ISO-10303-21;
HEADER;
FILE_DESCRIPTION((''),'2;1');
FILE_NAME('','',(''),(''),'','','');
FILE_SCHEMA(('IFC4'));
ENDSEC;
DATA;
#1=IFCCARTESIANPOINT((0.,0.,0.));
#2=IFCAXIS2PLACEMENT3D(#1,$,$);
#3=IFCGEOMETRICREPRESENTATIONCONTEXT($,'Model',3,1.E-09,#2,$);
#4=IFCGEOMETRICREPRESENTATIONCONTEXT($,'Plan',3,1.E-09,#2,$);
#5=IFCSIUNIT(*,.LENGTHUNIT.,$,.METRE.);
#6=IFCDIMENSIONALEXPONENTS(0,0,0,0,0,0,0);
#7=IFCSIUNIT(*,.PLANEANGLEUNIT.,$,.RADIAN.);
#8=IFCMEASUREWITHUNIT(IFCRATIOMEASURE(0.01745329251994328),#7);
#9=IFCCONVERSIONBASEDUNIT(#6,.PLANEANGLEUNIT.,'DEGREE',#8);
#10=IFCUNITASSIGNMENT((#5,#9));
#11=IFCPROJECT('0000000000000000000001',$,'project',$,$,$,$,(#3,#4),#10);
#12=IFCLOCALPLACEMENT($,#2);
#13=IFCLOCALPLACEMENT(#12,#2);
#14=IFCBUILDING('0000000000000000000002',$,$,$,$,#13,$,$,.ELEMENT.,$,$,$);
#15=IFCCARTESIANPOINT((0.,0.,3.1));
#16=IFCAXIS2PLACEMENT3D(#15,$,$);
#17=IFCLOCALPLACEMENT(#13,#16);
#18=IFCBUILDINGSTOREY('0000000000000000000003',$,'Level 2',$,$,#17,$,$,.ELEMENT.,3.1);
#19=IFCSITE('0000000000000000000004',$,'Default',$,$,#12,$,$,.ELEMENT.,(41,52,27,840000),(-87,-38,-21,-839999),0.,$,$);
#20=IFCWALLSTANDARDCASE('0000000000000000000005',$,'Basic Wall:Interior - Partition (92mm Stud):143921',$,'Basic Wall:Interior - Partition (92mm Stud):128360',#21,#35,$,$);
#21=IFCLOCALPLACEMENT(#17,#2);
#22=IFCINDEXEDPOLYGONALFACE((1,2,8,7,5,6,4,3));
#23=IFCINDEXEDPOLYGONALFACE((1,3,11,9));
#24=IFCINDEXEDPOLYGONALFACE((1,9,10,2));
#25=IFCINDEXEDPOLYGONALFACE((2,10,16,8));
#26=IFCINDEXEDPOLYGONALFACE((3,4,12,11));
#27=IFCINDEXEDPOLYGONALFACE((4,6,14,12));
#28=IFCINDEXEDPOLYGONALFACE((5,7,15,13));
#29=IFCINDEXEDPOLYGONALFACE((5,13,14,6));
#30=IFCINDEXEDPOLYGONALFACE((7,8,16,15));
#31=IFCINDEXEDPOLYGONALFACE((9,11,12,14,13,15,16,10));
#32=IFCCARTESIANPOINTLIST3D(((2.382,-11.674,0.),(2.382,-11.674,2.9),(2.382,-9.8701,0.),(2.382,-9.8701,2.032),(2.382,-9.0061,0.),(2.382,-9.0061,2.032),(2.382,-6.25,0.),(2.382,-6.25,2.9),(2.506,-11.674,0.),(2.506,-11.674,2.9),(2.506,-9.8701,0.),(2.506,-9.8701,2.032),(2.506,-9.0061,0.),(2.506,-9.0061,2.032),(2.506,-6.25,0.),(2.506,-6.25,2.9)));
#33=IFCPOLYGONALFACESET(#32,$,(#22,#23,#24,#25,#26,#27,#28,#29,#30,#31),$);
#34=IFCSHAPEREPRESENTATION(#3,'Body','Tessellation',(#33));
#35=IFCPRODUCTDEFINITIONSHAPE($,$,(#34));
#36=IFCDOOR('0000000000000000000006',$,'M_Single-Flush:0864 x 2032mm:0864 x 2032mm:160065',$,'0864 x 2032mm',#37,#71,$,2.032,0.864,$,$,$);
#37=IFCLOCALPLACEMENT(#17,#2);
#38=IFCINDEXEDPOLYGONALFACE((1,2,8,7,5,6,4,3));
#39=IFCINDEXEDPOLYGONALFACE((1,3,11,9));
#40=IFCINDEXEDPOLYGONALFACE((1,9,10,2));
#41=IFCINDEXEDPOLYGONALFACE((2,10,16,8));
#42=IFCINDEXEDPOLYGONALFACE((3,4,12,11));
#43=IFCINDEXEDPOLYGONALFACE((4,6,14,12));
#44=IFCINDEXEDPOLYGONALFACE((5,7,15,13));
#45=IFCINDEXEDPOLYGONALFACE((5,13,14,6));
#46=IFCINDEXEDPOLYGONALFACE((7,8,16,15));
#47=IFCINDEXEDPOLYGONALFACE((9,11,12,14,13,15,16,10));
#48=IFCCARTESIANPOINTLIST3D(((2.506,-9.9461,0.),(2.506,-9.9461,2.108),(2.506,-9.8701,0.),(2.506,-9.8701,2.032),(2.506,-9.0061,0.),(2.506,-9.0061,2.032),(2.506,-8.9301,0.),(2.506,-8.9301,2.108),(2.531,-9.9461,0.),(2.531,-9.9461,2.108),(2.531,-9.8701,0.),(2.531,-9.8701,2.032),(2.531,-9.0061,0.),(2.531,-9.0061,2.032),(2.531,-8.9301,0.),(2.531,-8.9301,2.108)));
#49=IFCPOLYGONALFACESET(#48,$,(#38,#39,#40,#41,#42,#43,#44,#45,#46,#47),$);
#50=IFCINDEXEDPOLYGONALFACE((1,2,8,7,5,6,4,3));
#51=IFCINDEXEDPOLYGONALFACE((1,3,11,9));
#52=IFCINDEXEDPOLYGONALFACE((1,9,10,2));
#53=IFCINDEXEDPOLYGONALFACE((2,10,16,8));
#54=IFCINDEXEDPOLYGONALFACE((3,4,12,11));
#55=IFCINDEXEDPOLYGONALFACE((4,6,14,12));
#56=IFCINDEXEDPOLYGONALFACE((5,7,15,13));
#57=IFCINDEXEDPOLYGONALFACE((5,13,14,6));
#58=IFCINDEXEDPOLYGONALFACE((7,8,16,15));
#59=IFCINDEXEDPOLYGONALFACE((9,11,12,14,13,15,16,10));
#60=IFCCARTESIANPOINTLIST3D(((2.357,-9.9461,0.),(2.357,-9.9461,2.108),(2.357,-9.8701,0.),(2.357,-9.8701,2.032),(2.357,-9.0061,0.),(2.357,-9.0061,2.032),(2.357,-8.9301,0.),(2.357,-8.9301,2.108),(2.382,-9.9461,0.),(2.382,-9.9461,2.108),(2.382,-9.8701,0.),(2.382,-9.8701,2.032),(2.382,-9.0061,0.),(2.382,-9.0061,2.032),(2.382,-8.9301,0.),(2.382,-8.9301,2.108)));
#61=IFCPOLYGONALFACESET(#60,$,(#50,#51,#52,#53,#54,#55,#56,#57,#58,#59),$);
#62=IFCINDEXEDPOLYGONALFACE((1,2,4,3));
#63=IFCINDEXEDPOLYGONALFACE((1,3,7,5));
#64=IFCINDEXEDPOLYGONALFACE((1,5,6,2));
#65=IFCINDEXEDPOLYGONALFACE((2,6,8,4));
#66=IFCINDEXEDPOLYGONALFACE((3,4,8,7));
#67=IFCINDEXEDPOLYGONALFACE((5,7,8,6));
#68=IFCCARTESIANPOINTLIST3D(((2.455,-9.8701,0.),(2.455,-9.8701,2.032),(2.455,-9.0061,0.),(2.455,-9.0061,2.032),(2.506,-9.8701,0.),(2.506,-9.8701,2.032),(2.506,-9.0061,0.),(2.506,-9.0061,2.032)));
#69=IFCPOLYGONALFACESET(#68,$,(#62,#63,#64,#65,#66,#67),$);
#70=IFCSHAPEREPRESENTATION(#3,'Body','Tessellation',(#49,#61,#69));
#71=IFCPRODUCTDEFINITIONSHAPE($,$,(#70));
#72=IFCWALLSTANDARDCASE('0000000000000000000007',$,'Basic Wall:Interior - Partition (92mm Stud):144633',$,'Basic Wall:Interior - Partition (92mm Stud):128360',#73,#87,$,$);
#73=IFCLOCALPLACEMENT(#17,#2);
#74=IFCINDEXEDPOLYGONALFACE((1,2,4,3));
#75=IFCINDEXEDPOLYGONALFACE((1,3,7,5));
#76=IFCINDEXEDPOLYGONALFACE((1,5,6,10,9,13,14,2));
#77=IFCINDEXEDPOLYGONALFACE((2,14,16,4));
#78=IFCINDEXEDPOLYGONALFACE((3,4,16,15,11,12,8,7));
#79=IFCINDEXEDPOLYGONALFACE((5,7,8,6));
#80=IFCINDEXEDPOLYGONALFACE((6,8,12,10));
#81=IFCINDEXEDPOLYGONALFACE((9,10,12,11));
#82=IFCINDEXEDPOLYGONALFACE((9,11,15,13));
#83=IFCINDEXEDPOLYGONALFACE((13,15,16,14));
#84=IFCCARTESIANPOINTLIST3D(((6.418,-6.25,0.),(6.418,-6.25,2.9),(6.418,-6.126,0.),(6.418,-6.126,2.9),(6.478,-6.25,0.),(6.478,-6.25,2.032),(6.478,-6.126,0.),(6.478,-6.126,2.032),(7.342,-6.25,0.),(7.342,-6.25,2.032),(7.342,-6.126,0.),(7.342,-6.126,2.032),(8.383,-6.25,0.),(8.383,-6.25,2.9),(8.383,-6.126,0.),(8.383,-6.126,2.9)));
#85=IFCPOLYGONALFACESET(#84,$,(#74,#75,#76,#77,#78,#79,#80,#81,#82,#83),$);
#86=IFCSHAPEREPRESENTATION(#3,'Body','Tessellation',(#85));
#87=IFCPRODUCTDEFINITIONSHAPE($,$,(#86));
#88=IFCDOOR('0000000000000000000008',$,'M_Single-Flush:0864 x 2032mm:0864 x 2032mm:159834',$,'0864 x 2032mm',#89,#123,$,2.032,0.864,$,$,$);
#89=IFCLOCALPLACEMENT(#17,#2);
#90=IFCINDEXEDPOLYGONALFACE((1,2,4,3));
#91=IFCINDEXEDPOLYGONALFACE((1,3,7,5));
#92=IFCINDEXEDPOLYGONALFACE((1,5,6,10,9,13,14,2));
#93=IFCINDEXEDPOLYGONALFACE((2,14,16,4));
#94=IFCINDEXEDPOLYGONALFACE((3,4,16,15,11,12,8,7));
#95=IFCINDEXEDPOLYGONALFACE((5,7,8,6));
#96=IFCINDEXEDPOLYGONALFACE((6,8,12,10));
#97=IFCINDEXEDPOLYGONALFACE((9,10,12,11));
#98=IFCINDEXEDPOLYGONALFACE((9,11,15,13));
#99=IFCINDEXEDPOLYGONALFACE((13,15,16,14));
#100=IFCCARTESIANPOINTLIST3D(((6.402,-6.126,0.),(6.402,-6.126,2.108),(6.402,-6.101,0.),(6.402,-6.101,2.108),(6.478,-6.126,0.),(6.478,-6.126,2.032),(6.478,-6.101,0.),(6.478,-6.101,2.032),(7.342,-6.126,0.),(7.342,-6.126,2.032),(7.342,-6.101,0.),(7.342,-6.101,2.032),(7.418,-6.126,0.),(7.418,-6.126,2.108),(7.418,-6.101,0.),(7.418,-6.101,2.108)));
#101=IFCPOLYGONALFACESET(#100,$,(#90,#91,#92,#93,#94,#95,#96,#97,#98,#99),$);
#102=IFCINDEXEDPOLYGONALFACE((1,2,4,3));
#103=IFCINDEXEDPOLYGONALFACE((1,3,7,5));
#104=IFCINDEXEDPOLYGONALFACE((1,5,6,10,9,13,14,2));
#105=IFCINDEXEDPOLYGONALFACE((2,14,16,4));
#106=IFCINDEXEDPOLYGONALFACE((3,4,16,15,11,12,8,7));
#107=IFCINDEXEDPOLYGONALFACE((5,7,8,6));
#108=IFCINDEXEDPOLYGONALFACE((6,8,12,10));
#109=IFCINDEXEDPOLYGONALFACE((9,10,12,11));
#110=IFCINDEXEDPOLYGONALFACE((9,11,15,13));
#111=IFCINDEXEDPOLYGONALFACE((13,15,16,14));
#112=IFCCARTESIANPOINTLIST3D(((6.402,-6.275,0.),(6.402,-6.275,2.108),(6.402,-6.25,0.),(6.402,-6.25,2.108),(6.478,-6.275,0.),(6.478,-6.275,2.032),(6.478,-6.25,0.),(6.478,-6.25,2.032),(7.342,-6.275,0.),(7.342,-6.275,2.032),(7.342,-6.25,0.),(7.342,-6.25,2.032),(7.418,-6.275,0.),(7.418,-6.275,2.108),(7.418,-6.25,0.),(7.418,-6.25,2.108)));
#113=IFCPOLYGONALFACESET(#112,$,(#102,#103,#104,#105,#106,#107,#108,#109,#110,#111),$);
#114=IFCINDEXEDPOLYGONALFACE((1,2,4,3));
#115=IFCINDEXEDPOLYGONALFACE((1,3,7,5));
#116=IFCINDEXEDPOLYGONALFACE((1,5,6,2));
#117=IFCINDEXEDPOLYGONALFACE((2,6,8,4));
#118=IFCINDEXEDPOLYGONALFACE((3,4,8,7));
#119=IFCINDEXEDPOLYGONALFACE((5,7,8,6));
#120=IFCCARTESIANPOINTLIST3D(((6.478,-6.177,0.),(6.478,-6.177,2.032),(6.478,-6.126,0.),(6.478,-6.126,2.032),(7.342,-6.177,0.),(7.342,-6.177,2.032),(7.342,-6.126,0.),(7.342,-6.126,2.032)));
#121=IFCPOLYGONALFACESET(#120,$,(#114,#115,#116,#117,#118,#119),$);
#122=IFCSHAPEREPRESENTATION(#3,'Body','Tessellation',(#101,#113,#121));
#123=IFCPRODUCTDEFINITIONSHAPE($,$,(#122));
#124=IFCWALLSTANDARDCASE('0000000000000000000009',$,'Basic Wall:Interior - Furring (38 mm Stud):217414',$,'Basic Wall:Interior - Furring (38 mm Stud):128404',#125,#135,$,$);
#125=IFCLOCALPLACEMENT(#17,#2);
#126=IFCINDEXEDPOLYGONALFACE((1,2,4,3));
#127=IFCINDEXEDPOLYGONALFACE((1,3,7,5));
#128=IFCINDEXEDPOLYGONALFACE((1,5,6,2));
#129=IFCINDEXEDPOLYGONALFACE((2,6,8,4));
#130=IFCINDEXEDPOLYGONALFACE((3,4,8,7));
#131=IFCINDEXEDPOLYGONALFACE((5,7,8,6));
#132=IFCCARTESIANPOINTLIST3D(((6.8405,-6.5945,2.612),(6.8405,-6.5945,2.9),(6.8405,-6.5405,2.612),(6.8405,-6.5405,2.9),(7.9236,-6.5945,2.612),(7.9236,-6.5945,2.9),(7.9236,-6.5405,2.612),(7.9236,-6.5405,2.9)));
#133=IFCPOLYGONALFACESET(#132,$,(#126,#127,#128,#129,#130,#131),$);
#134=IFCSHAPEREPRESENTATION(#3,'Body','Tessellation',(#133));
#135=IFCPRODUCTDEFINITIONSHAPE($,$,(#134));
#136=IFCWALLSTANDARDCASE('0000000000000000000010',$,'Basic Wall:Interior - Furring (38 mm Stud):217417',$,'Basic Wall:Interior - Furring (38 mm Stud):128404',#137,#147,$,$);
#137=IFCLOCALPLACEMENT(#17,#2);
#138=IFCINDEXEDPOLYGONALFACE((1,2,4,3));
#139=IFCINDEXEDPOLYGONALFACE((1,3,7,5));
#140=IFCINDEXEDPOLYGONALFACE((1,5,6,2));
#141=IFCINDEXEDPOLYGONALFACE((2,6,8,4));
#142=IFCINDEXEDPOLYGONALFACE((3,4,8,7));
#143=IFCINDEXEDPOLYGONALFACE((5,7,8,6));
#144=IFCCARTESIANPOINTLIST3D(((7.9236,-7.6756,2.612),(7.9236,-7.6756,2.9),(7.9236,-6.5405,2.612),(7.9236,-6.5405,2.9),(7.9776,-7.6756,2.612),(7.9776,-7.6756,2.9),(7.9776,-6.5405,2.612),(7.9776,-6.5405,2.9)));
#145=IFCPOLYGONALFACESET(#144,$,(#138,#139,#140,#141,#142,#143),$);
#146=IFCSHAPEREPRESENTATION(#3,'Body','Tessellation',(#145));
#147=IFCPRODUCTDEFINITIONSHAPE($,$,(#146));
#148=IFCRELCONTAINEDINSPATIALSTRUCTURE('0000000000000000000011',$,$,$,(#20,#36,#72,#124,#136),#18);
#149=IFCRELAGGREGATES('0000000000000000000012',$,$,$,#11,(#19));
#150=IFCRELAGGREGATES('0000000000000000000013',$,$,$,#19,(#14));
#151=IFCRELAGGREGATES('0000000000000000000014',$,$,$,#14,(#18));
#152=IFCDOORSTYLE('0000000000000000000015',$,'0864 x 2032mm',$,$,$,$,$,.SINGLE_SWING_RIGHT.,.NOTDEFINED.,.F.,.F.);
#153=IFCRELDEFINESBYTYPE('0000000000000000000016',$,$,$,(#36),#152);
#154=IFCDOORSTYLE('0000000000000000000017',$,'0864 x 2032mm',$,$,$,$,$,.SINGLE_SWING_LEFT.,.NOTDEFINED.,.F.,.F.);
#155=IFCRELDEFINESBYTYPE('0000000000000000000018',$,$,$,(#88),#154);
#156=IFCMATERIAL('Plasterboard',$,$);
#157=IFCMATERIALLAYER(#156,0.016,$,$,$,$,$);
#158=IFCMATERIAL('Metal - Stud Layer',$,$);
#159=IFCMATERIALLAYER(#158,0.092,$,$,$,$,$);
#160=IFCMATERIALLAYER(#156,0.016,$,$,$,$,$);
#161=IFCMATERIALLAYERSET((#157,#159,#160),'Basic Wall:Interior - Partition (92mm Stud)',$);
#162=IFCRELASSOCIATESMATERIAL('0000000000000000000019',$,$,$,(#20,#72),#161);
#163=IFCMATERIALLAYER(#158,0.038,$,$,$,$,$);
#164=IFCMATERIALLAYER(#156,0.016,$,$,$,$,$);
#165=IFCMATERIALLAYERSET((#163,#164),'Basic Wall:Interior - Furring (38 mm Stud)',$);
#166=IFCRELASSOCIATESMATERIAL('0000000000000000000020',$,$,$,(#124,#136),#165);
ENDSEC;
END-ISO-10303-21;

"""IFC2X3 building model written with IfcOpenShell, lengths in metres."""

from ifc_helpers import new_model, entity, si_unit, converted_unit, frame, frame_2d, origin, origin_2d_with_axis, place, context, project, spatial, polyline, rectangle, outline, extrude, source, transform, mapped, material, layer, layer_set, layer_usage, type_object, type_shapes, element, fill, save


model = new_model("IFC2X3")

# Units and contexts
model_context = context("Model", 3, precision=1e-09, world=origin())
plan_context = context("Plan", 3, precision=1e-09, world=origin())
ifc_project = project(units=[si_unit("LENGTHUNIT", "METRE"), converted_unit("PLANEANGLEUNIT", "DEGREE", entity("IfcRatioMeasure", 0.01745329251994328), si_unit("PLANEANGLEUNIT", "RADIAN"), dimensions=[0, 0, 0, 0, 0, 0, 0])], contexts=[model_context, plan_context])

# Site, building, storey
site_placement = place(None, origin())
site = spatial("IfcSite", under=ifc_project, at=site_placement, Name="Default", CompositionType="ELEMENT", RefLatitude=(41, 52, 27, 840000), RefLongitude=(-87, -38, -21, -839999), RefElevation=0.0)
building_placement = place(site_placement, origin())
building = spatial("IfcBuilding", under=site, at=building_placement, CompositionType="ELEMENT")
storey_placement = place(building_placement, frame((0.0, 0.0, 3.1)))
storey = spatial("IfcBuildingStorey", under=building, at=storey_placement, Name="Level 2", CompositionType="ELEMENT", Elevation=3.1)

# Shared definitions
ifc_material_1 = material(Name="Metal - Stud Layer")
ifc_material_2 = material(Name="Plasterboard")

# Walls, openings, doors
ifc_layer_1 = layer(ifc_material_2, 0.016)
ifc_layer_2 = layer(ifc_material_1, 0.092)
ifc_layer_3 = layer(ifc_material_2, 0.016)
ifc_layer_set_1 = layer_set([ifc_layer_1, ifc_layer_2, ifc_layer_3], Name="Basic Wall:Interior - Partition (92mm Stud)")
ifc_layer_usage_1 = layer_usage(ifc_layer_set_1, "AXIS2", "NEGATIVE", 0.062)
wall_1_placement = place(storey_placement, frame((2.444, -6.25, 0.0), z_axis=(0.0, 0.0, 1.0), x_axis=(0.0, -1.0, 0.0)))
wall_1 = element("IfcWallStandardCase", 1, at=wall_1_placement, inside=storey, material=ifc_layer_usage_1, Name="Basic Wall:Interior - Partition (92mm Stud):143921", ObjectType="Basic Wall:Interior - Partition (92mm Stud):128360", context=model_context, shape_type="SweptSolid", body=[
    extrude(rectangle(XDim=5.424, YDim=0.124, at=frame_2d((2.712, 0.0), x_axis=(-1.0, 0.0))), origin(), (0.0, 0.0, 1.0), 2.9),
])
opening_1_placement = place(wall_1_placement, frame((2.7561, -0.062, 0.0)))
opening_1 = element("IfcOpeningElement", 2, at=opening_1_placement, cuts=wall_1, ObjectType="Opening", context=model_context, shape_type="SweptSolid", body=[
    extrude(rectangle(XDim=0.864, YDim=2.032, at=frame_2d((1.016, 0.432), x_axis=(0.0, 1.0))), frame((0.0, 0.0, 0.0), z_axis=(0.0, 1.0, 0.0), x_axis=(0.0, 0.0, 1.0)), (0.0, 0.0, 1.0), 0.124),
])
door_style_1 = type_object("IfcDoorStyle", Name="0864 x 2032mm", ConstructionType="NOTDEFINED", OperationType="SINGLE_SWING_RIGHT", ParameterTakesPrecedence=False, Sizeable=False)
shared_shape_1 = source(origin(), model_context, "Body", "SweptSolid", [
    extrude(outline(polyline([(-0.508, -1.073), (0.508, -1.073), (0.508, 1.035), (0.432, 1.035), (0.432, -0.997), (-0.432, -0.997), (-0.432, 1.035), (-0.508, 1.035), (-0.508, -1.073)])), frame((0.432, 0.124, 1.035), z_axis=(0.0, 1.0, 0.0), x_axis=(1.0, 0.0, 0.0)), (0.0, 0.0, 1.0), 0.025),
    extrude(outline(polyline([(-1.073, -0.508), (1.035, -0.508), (1.035, -0.432), (-0.997, -0.432), (-0.997, 0.432), (1.035, 0.432), (1.035, 0.508), (-1.073, 0.508), (-1.073, -0.508)])), frame((0.432, -0.025, 1.035), z_axis=(0.0, 1.0, 0.0), x_axis=(0.0, 0.0, -1.0)), (0.0, 0.0, 1.0), 0.025),
    extrude(rectangle(XDim=0.051, YDim=0.864, at=origin_2d_with_axis()), frame((0.432, 0.0985, 0.0), z_axis=(0.0, 0.0, 1.0), x_axis=(0.0, 1.0, 0.0)), (0.0, 0.0, 1.0), 2.032),
])
type_shapes(door_style_1, [shared_shape_1])
door_1_placement = place(opening_1_placement, origin())
door_1 = element("IfcDoor", 3, at=door_1_placement, inside=storey, type_object=door_style_1, Name="M_Single-Flush:0864 x 2032mm:0864 x 2032mm:160065", ObjectType="0864 x 2032mm", OverallHeight=2.032, OverallWidth=0.864, context=model_context, shape_type="MappedRepresentation", body=[
    mapped(shared_shape_1, transform((0.0, 0.0, 0.0), scale=1.0)),
])
fill(opening_1, door_1)
ifc_layer_usage_2 = layer_usage(ifc_layer_set_1, "AXIS2", "NEGATIVE", 0.062)
wall_2_placement = place(storey_placement, frame((6.418, -6.188, 0.0)))
wall_2 = element("IfcWallStandardCase", 4, at=wall_2_placement, inside=storey, material=ifc_layer_usage_2, Name="Basic Wall:Interior - Partition (92mm Stud):144633", ObjectType="Basic Wall:Interior - Partition (92mm Stud):128360", context=model_context, shape_type="SweptSolid", body=[
    extrude(rectangle(XDim=1.965, YDim=0.124, at=frame_2d((0.9825, 0.0), x_axis=(-1.0, 0.0))), origin(), (0.0, 0.0, 1.0), 2.9),
])
opening_2_placement = place(wall_2_placement, frame((0.06, -0.062, 0.0)))
opening_2 = element("IfcOpeningElement", 5, at=opening_2_placement, cuts=wall_2, ObjectType="Opening", context=model_context, shape_type="SweptSolid", body=[
    extrude(rectangle(XDim=0.864, YDim=2.032, at=frame_2d((1.016, 0.432), x_axis=(0.0, -1.0))), frame((0.0, 0.0, 0.0), z_axis=(0.0, 1.0, 0.0), x_axis=(0.0, 0.0, 1.0)), (0.0, 0.0, 1.0), 0.124),
])
door_style_2 = type_object("IfcDoorStyle", Name="0864 x 2032mm", ConstructionType="NOTDEFINED", OperationType="SINGLE_SWING_LEFT", ParameterTakesPrecedence=False, Sizeable=False)
shared_shape_2 = source(origin(), model_context, "Body", "SweptSolid", [
    extrude(outline(polyline([(-0.508, -1.073), (0.508, -1.073), (0.508, 1.035), (0.432, 1.035), (0.432, -0.997), (-0.432, -0.997), (-0.432, 1.035), (-0.508, 1.035), (-0.508, -1.073)])), frame((0.432, 0.149, 1.035), z_axis=(0.0, -1.0, 0.0), x_axis=(-1.0, 0.0, 0.0)), (0.0, 0.0, 1.0), 0.025),
    extrude(outline(polyline([(-1.073, -0.508), (1.035, -0.508), (1.035, -0.432), (-0.997, -0.432), (-0.997, 0.432), (1.035, 0.432), (1.035, 0.508), (-1.073, 0.508), (-1.073, -0.508)])), frame((0.432, 0.0, 1.035), z_axis=(0.0, -1.0, 0.0), x_axis=(0.0, 0.0, -1.0)), (0.0, 0.0, 1.0), 0.025),
    extrude(rectangle(XDim=0.864, YDim=0.051, at=origin_2d_with_axis()), frame((0.432, 0.0985, 0.0)), (0.0, 0.0, 1.0), 2.032),
])
type_shapes(door_style_2, [shared_shape_2])
door_2_placement = place(opening_2_placement, origin())
door_2 = element("IfcDoor", 6, at=door_2_placement, type_object=door_style_2, Name="M_Single-Flush:0864 x 2032mm:0864 x 2032mm:159834", ObjectType="0864 x 2032mm", OverallHeight=2.032, OverallWidth=0.864, context=model_context, shape_type="MappedRepresentation", body=[
    mapped(shared_shape_2, transform((0.0, 0.0, 0.0), scale=1.0)),
])
fill(opening_2, door_2)

# Walls
ifc_layer_4 = layer(ifc_material_1, 0.038)
ifc_layer_5 = layer(ifc_material_2, 0.016)
ifc_layer_set_2 = layer_set([ifc_layer_4, ifc_layer_5], Name="Basic Wall:Interior - Furring (38 mm Stud)")
ifc_layer_usage_3 = layer_usage(ifc_layer_set_2, "AXIS2", "NEGATIVE", 0.027)
wall_3_placement = place(storey_placement, frame((6.8405, -6.5675, 2.612)))
element("IfcWallStandardCase", 7, at=wall_3_placement, inside=storey, material=ifc_layer_usage_3, Name="Basic Wall:Interior - Furring (38 mm Stud):217414", ObjectType="Basic Wall:Interior - Furring (38 mm Stud):128404", context=model_context, shape_type="SweptSolid", body=[
    extrude(rectangle(XDim=1.0831, YDim=0.054, at=frame_2d((0.5416, 0.0), x_axis=(-1.0, 0.0))), origin(), (0.0, 0.0, 1.0), 0.288),
])
ifc_layer_usage_4 = layer_usage(ifc_layer_set_2, "AXIS2", "NEGATIVE", 0.027)
wall_4_placement = place(storey_placement, frame((7.9506, -6.5405, 2.612), z_axis=(0.0, 0.0, 1.0), x_axis=(0.0, -1.0, 0.0)))
element("IfcWallStandardCase", 8, at=wall_4_placement, inside=storey, material=ifc_layer_usage_4, Name="Basic Wall:Interior - Furring (38 mm Stud):217417", ObjectType="Basic Wall:Interior - Furring (38 mm Stud):128404", context=model_context, shape_type="SweptSolid", body=[
    extrude(rectangle(XDim=1.1351, YDim=0.054, at=frame_2d((0.5675, 0.0), x_axis=(-1.0, 0.0))), origin(), (0.0, 0.0, 1.0), 0.288),
])

save(model, "model.ifc")
